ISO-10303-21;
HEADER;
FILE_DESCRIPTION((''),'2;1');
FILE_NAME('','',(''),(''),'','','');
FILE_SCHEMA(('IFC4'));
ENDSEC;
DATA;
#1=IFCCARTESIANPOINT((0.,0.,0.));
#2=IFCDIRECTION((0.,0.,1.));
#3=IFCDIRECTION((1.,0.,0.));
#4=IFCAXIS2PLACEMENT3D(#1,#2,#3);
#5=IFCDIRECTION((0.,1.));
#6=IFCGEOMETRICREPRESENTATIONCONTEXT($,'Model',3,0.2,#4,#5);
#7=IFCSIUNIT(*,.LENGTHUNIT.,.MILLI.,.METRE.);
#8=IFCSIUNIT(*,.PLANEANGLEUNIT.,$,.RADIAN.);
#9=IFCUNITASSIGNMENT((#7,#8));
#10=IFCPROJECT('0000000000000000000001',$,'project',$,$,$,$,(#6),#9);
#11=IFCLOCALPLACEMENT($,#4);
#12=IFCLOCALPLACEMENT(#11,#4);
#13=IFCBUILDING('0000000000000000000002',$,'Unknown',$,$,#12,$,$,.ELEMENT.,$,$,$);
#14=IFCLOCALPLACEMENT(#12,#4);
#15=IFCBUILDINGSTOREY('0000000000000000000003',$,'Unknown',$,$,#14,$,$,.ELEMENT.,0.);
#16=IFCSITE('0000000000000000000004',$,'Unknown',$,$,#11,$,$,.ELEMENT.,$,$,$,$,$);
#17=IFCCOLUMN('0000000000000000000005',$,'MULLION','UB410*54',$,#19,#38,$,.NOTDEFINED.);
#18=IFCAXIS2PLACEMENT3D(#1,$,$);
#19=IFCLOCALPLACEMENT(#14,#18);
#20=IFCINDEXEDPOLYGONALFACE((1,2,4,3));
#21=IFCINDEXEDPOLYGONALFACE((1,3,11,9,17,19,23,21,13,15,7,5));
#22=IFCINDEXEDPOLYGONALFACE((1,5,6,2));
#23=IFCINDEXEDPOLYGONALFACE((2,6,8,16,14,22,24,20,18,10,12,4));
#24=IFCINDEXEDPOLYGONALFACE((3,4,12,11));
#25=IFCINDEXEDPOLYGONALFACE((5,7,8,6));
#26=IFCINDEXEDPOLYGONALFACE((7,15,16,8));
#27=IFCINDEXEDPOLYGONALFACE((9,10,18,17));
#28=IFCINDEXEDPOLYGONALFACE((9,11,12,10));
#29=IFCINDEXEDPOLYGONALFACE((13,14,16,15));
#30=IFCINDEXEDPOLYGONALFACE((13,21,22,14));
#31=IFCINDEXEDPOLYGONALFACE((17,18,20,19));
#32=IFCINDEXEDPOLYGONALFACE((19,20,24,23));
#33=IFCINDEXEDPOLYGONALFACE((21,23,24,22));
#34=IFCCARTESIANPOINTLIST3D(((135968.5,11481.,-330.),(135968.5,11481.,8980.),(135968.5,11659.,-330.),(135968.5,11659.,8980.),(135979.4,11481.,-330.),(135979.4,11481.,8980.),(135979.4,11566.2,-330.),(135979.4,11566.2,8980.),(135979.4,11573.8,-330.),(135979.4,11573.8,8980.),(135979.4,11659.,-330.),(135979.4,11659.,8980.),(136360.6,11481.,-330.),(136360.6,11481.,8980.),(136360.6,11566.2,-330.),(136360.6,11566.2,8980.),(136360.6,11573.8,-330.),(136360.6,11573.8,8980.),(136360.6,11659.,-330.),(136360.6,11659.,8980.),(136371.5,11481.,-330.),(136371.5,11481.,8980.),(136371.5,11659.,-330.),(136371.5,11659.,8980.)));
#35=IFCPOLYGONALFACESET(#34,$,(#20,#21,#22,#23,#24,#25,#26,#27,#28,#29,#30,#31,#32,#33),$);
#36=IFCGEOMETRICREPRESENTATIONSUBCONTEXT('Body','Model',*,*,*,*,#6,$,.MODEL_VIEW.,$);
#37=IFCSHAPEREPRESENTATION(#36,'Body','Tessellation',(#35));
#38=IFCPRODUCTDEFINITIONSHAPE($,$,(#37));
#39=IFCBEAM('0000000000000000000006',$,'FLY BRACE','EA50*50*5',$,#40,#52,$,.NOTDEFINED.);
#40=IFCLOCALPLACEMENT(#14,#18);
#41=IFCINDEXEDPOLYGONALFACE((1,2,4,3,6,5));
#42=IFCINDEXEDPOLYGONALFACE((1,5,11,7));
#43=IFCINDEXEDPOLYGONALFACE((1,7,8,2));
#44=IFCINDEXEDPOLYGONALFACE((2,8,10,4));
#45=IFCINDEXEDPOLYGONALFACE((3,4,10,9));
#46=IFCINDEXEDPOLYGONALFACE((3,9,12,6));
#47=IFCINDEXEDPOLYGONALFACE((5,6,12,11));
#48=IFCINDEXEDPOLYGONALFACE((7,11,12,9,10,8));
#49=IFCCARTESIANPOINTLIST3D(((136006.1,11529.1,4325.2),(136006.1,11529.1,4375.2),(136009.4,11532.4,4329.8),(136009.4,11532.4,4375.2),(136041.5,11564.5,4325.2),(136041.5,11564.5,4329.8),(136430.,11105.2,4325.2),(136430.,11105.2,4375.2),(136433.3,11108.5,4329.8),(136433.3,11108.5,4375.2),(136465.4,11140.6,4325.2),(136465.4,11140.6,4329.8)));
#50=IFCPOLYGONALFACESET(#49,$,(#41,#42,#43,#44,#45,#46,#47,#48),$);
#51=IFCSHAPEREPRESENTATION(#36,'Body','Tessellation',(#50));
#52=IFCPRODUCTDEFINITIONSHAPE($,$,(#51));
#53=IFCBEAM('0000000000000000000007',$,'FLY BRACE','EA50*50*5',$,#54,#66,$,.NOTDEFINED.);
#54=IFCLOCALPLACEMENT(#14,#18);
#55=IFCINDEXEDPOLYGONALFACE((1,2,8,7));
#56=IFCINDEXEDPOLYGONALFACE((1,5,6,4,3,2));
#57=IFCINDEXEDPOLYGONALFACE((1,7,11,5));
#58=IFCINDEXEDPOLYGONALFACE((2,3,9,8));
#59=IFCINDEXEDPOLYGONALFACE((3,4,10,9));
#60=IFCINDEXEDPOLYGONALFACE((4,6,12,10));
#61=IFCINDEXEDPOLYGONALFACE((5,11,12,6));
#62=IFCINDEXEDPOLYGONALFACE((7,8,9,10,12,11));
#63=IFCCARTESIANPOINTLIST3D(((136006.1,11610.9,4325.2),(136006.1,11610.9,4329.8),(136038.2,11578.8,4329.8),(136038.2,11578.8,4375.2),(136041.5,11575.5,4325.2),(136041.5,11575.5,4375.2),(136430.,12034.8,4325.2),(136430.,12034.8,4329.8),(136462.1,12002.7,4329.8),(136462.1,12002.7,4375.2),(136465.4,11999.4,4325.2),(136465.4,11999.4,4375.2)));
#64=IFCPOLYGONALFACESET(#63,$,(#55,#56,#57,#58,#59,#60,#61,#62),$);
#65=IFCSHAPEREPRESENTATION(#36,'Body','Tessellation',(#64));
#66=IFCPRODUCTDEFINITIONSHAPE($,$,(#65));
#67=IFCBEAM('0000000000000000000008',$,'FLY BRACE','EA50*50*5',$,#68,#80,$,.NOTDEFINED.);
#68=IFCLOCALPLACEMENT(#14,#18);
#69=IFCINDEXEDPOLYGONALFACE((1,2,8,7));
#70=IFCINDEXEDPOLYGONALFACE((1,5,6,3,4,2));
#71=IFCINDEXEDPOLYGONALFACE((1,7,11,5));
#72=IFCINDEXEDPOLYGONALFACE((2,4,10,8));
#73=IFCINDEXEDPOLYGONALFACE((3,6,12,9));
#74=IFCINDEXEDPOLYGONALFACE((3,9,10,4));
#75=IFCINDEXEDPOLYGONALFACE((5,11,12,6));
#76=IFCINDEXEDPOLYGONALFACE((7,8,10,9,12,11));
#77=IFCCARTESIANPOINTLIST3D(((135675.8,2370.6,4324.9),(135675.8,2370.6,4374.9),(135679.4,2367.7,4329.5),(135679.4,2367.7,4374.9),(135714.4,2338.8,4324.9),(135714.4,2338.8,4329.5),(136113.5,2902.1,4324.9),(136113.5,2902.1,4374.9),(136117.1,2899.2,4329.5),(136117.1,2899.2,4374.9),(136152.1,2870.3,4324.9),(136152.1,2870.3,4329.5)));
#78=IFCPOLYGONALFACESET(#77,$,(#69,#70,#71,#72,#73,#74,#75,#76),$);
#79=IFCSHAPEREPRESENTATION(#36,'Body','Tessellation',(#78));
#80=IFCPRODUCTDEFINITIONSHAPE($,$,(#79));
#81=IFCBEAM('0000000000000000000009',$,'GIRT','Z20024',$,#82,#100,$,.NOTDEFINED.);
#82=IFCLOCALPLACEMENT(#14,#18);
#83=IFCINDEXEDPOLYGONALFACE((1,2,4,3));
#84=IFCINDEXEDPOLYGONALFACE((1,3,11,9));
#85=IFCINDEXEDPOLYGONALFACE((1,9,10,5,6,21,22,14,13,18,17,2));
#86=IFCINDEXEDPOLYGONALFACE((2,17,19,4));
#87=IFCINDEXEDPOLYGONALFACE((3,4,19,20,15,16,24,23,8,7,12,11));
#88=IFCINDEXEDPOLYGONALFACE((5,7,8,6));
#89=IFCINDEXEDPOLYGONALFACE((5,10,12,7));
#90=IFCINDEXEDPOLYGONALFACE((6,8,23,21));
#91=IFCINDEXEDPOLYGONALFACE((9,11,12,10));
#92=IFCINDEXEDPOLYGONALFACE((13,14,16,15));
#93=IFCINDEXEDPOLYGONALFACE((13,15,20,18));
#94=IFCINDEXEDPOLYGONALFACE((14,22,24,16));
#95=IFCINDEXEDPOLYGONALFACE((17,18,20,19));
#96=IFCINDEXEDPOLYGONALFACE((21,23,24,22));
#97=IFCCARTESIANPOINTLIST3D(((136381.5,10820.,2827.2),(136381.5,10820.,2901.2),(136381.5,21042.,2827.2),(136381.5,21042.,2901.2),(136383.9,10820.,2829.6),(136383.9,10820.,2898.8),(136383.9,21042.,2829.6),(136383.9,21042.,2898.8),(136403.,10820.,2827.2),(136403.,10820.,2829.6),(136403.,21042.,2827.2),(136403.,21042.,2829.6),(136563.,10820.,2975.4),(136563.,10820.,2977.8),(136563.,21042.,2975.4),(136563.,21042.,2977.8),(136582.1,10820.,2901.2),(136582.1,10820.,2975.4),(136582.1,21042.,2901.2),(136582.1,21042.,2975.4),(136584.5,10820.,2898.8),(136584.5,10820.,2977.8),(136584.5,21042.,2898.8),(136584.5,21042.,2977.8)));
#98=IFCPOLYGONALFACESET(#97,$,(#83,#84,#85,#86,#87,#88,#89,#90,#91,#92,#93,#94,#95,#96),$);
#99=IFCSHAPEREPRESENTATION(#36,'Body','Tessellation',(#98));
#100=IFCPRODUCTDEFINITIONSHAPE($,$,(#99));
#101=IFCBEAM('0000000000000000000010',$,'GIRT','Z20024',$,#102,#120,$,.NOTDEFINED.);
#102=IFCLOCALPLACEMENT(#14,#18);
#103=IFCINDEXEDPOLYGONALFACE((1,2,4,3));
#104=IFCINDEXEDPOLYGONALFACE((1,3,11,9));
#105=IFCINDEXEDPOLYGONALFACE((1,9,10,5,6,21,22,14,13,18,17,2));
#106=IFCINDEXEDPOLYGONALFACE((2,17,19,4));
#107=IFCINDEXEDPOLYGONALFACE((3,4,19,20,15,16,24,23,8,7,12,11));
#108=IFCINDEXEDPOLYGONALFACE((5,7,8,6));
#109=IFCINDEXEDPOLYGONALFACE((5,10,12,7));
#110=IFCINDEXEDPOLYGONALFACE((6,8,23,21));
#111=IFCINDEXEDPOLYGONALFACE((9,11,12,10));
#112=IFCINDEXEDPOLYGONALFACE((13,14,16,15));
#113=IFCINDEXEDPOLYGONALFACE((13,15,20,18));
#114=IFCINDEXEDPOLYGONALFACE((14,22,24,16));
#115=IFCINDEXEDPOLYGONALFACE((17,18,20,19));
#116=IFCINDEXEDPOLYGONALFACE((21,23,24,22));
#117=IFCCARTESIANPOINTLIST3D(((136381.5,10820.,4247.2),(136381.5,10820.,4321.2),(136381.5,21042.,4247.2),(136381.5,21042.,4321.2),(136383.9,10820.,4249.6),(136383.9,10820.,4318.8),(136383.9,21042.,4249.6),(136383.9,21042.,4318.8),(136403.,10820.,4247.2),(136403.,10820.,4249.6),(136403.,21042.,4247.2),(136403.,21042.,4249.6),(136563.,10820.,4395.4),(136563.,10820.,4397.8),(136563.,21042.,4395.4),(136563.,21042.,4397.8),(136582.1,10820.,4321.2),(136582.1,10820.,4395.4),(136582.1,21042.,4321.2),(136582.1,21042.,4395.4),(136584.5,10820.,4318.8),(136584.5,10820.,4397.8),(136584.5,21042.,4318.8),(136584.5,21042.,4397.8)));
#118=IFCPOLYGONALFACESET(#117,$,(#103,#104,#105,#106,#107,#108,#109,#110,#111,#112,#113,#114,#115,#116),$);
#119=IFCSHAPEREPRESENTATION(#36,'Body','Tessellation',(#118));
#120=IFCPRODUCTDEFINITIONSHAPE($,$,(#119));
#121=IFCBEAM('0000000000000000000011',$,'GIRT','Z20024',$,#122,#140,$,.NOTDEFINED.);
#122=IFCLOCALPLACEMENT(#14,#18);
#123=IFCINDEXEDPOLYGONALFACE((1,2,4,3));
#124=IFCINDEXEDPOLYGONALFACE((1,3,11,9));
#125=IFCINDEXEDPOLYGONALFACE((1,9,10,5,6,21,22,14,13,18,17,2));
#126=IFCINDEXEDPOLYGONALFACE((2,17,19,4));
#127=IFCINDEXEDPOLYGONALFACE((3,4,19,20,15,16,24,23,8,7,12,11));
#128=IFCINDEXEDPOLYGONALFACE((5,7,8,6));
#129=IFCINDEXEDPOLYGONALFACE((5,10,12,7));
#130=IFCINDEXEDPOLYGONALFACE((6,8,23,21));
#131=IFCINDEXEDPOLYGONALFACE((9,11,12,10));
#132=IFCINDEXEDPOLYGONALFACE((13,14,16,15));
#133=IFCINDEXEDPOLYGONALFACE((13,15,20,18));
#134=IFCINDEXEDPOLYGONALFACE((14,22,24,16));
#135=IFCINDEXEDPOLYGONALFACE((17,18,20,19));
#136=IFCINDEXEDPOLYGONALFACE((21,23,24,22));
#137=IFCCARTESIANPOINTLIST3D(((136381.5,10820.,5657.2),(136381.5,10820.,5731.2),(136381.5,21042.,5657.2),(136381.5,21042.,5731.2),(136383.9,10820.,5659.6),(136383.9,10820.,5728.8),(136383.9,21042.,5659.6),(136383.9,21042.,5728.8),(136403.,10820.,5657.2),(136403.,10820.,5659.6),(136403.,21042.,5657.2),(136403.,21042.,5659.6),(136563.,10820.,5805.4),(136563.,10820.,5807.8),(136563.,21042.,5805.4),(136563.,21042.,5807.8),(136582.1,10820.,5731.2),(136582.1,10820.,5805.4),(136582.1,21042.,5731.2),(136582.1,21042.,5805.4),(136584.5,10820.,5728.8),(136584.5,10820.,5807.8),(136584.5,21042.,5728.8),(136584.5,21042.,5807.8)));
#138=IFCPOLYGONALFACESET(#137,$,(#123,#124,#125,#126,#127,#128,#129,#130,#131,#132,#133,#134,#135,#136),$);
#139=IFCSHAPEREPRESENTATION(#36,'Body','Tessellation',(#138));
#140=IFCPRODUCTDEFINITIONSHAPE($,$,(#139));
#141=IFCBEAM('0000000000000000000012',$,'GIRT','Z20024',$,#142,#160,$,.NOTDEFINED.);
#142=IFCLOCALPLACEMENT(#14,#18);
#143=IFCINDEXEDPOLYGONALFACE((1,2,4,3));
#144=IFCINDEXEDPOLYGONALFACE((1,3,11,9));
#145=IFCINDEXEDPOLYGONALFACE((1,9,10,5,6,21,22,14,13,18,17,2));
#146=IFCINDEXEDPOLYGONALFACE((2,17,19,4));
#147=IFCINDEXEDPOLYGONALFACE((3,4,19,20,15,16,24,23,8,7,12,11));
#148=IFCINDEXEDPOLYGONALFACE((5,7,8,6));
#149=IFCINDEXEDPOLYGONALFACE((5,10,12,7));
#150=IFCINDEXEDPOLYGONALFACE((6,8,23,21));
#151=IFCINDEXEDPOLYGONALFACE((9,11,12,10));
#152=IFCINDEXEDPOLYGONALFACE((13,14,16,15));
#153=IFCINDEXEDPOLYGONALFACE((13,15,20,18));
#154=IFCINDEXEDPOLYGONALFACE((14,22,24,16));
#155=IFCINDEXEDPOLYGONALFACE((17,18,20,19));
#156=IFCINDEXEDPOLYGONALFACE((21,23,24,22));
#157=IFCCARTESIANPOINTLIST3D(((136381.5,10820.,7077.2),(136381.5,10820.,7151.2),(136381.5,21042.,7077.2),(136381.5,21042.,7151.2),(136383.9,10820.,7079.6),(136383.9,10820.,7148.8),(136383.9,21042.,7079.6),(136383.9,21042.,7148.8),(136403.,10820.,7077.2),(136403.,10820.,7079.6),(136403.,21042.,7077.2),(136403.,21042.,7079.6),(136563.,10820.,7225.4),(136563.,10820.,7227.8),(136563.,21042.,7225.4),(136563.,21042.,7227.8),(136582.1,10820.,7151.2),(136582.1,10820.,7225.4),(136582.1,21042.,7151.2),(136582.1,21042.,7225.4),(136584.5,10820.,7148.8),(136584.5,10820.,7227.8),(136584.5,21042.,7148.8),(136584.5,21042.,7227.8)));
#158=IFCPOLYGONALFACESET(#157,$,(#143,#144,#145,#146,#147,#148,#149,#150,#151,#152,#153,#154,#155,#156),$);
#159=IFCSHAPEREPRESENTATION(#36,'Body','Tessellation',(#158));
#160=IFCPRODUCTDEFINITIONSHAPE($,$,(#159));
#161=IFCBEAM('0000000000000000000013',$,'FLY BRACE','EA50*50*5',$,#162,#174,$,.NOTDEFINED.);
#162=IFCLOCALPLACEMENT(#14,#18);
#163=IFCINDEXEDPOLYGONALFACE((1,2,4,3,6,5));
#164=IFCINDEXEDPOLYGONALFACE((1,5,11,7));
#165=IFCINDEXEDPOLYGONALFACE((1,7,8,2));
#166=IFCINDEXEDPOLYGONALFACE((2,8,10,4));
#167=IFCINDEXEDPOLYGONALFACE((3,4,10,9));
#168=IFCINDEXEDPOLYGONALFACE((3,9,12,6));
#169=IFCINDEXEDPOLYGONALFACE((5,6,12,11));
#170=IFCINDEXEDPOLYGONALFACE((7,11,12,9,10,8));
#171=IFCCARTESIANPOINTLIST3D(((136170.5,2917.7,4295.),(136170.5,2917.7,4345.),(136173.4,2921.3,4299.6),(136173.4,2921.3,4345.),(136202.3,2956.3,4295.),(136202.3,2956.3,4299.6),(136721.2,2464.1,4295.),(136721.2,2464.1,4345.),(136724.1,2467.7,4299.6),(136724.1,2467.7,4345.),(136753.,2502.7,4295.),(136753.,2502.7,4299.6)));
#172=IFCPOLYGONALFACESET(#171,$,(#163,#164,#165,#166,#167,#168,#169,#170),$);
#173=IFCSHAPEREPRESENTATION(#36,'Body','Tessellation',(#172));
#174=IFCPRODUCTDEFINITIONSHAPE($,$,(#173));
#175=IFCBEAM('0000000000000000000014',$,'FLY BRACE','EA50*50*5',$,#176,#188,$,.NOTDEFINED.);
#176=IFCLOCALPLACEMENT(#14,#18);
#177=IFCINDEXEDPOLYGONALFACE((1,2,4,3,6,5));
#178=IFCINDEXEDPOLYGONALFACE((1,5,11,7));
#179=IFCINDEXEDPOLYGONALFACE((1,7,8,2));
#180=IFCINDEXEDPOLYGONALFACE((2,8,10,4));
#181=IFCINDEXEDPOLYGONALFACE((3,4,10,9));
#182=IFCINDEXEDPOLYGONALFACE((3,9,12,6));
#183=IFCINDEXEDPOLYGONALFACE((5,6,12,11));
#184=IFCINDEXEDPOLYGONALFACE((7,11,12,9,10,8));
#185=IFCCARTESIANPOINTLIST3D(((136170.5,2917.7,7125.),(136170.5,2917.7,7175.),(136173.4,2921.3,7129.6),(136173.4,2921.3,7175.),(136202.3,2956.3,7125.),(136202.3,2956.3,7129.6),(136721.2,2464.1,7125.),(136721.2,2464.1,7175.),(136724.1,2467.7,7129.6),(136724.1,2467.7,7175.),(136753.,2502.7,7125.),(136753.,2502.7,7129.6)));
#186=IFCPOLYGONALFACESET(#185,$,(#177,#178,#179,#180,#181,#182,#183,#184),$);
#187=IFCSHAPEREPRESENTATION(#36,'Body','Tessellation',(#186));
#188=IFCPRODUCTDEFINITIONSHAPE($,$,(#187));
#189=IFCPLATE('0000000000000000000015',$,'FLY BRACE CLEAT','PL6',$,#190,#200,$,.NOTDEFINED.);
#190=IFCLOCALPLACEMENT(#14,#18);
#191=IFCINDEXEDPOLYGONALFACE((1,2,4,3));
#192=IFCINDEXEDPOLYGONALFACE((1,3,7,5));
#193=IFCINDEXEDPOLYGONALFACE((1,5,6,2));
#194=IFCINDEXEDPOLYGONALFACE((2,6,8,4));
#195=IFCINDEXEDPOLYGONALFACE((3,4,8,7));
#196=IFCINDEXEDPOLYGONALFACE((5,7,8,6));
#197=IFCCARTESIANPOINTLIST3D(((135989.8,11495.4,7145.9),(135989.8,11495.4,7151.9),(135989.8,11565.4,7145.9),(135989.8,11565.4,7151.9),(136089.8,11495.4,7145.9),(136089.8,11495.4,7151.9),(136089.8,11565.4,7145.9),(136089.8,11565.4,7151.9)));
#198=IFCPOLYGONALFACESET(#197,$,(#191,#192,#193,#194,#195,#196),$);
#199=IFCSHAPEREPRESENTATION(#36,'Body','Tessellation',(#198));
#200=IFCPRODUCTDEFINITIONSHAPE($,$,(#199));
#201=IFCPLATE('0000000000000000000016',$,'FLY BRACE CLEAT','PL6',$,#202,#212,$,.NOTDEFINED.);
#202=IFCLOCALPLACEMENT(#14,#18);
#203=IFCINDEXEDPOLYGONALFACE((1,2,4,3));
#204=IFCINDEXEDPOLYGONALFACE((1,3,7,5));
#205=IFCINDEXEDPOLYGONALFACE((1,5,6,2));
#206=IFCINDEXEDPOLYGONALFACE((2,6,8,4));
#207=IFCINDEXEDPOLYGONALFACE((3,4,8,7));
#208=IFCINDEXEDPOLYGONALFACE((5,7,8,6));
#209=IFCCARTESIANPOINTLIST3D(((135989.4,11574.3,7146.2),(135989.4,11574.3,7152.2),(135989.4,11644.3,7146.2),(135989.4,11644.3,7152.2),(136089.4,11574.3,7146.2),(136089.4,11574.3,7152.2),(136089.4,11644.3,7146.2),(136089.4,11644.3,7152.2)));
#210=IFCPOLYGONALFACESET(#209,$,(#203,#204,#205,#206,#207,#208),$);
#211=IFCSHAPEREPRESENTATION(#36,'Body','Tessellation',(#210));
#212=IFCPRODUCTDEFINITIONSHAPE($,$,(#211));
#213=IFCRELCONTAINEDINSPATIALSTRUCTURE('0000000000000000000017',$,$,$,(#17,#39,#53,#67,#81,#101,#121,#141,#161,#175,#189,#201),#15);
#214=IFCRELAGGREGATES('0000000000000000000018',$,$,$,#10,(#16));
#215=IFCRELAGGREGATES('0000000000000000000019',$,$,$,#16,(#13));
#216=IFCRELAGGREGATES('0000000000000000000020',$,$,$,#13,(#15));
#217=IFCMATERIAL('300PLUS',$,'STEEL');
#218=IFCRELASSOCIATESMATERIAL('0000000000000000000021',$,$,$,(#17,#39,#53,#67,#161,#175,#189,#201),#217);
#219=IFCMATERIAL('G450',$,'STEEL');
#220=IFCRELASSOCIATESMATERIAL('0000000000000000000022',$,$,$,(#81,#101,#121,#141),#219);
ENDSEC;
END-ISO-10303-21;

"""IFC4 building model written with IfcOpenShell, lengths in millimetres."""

from ifc_helpers import new_model, si_unit, direction, frame, origin_with_axes, place, context, subcontext, project, spatial, line, indexed_curve, outline, extrude, material, element, save


model = new_model("IFC4")

# Units and contexts
model_context = context("Model", 3, precision=0.2, world=origin_with_axes(), true_north=direction((0.0, 1.0)))
body_context = subcontext(model_context, "Body", "Model", "MODEL_VIEW")
ifc_project = project(units=[si_unit("LENGTHUNIT", "METRE", prefix="MILLI"), si_unit("PLANEANGLEUNIT", "RADIAN")], contexts=[model_context])

# Site, building, storey
site_placement = place(None, origin_with_axes())
site = spatial("IfcSite", under=ifc_project, at=site_placement, Name="Unknown", CompositionType="ELEMENT")
building_placement = place(site_placement, origin_with_axes())
building = spatial("IfcBuilding", under=site, at=building_placement, Name="Unknown", CompositionType="ELEMENT")
storey_placement = place(building_placement, origin_with_axes())
storey = spatial("IfcBuildingStorey", under=building, at=storey_placement, Name="Unknown", CompositionType="ELEMENT", Elevation=0.0)

# Column
ifc_material_1 = material(Name="G450", Category="STEEL")
ifc_material_2 = material(Name="300PLUS", Category="STEEL")
column_placement = place(storey_placement, frame((136170.0, 11570.0, -330.0), z_axis=(0.0, -1.0, 0.0), x_axis=(0.0, 0.0, 1.0)))
element("IfcColumn", 1, at=column_placement, inside=storey, material=ifc_material_2, Name="MULLION", Description="UB410*54", PredefinedType="NOTDEFINED", context=body_context, shape_type="SolidModel", body=[
    extrude(outline(indexed_curve([(-89.0, -201.5), (89.0, -201.5), (89.0, -190.6), (3.8, -190.6), (3.8, 190.6), (89.0, 190.6), (89.0, 201.5), (-89.0, 201.5), (-89.0, 190.6), (-3.8, 190.6), (-3.8, -190.6), (-89.0, -190.6)], segments=[line(1, 2, 3, 4, 5, 6, 7, 8, 9, 10, 11, 12, 1)])), frame((0.0, 0.0, 0.0), z_axis=(-1.0, 0.0, 0.0), x_axis=(0.0, 0.0, 1.0)), (0.0, 0.0, -1.0), 9310.0),
])

# Beams
for number, where, z_axis, x_axis, name in (
    (2, (136023.8, 11546.8, 4350.2), (0.0, 0.0, 1.0), (0.707107, -0.707107, 0.0), "FLY BRACE"),
    (3, (136023.8, 11593.2, 4350.2), (0.0, 0.0, 1.0), (0.707107, 0.707107, 0.0), "FLY BRACE"),
):
    element("IfcBeam", number, at=place(storey_placement, frame(where, z_axis=z_axis, x_axis=x_axis)), inside=storey, material=ifc_material_2, Name=name, Description="EA50*50*5", PredefinedType="NOTDEFINED", context=body_context, shape_type="SolidModel", body=[
        extrude(outline(indexed_curve([(-25.0, -25.0), (25.0, -25.0), (25.0, -20.4), (-20.4, -20.4), (-20.4, 25.0), (-25.0, 25.0)], segments=[line(1, 2, 3, 4, 5, 6, 1)])), frame((0.0, 0.0, 0.0), z_axis=(-1.0, 0.0, 0.0), x_axis=(0.0, 0.0, 1.0)), (0.0, 0.0, -1.0), 599.5),
    ])
beam_placement = place(storey_placement, frame((136132.8, 2886.2, 4349.9), z_axis=(0.0, 0.0, 1.0), x_axis=(-0.635702, -0.771934, 0.0)))
element("IfcBeam", 4, at=beam_placement, inside=storey, material=ifc_material_2, Name="FLY BRACE", Description="EA50*50*5", PredefinedType="NOTDEFINED", context=body_context, shape_type="SolidModel", body=[
    extrude(outline(indexed_curve([(-25.0, -25.0), (25.0, -25.0), (25.0, -20.4), (-20.4, -20.4), (-20.4, 25.0), (-25.0, 25.0)], segments=[line(1, 2, 3, 4, 5, 6, 1)])), frame((0.0, 0.0, 0.0), z_axis=(-1.0, 0.0, 0.0), x_axis=(0.0, 0.0, 1.0)), (0.0, 0.0, -1.0), 688.5),
])
for number, where, z_axis, x_axis, name in (
    (5, (136483.0, 10820.0, 2900.0), (0.0, 0.0, -1.0), (0.0, 1.0, 0.0), "GIRT"),
    (6, (136483.0, 10820.0, 4320.0), (0.0, 0.0, -1.0), (0.0, 1.0, 0.0), "GIRT"),
    (7, (136483.0, 10820.0, 5730.0), (0.0, 0.0, -1.0), (0.0, 1.0, 0.0), "GIRT"),
    (8, (136483.0, 10820.0, 7150.0), (0.0, 0.0, -1.0), (0.0, 1.0, 0.0), "GIRT"),
):
    element("IfcBeam", number, at=place(storey_placement, frame(where, z_axis=z_axis, x_axis=x_axis)), inside=storey, material=ifc_material_1, Name=name, Description="Z20024", PredefinedType="NOTDEFINED", context=body_context, shape_type="SolidModel", body=[
        extrude(outline(indexed_curve([(72.8, -101.5), (72.8, -80.0), (70.4, -80.0), (70.4, -99.1), (1.2, -99.1), (1.2, 101.5), (-77.8, 101.5), (-77.8, 80.0), (-75.4, 80.0), (-75.4, 99.1), (-1.2, 99.1), (-1.2, -101.5)], segments=[line(1, 2, 3, 4, 5, 6, 7, 8, 9, 10, 11, 12, 1)])), frame((0.0, 0.0, 0.0), z_axis=(-1.0, 0.0, 0.0), x_axis=(0.0, 0.0, 1.0)), (0.0, 0.0, -1.0), 10222.0),
    ])
for number, where, z_axis, x_axis, name in (
    (9, (136186.4, 2937.0, 4320.0), (0.0, 0.0, 1.0), (0.771874, -0.635776, 0.0), "FLY BRACE"),
    (10, (136186.4, 2937.0, 7150.0), (0.0, 0.0, 1.0), (0.771874, -0.635776, 0.0), "FLY BRACE"),
):
    element("IfcBeam", number, at=place(storey_placement, frame(where, z_axis=z_axis, x_axis=x_axis)), inside=storey, material=ifc_material_2, Name=name, Description="EA50*50*5", PredefinedType="NOTDEFINED", context=body_context, shape_type="SolidModel", body=[
        extrude(outline(indexed_curve([(-25.0, -25.0), (25.0, -25.0), (25.0, -20.4), (-20.4, -20.4), (-20.4, 25.0), (-25.0, 25.0)], segments=[line(1, 2, 3, 4, 5, 6, 1)])), frame((0.0, 0.0, 0.0), z_axis=(-1.0, 0.0, 0.0), x_axis=(0.0, 0.0, 1.0)), (0.0, 0.0, -1.0), 713.5),
    ])

# Plates
for number, where, z_axis, x_axis, name in (
    (11, (135989.8, 11565.4, 7148.9), (0.0, 0.0, 1.0), (0.0, -1.0, 0.0), "FLY BRACE CLEAT"),
    (12, (136089.4, 11574.3, 7149.2), (0.0, 0.0, 1.0), (0.0, 1.0, 0.0), "FLY BRACE CLEAT"),
):
    element("IfcPlate", number, at=place(storey_placement, frame(where, z_axis=z_axis, x_axis=x_axis)), inside=storey, material=ifc_material_2, Name=name, Description="PL6", PredefinedType="NOTDEFINED", context=body_context, shape_type="SolidModel", body=[
        extrude(outline(indexed_curve([(0.0, 0.0), (70.0, 0.0), (70.0, 100.0), (0.0, 100.0)], segments=[line(1, 2, 3, 4, 1)])), frame((0.0, 0.0, 3.0), z_axis=(0.0, 0.0, 1.0), x_axis=(1.0, 0.0, 0.0)), (0.0, 0.0, -1.0), 6.0),
    ])

save(model, "model.ifc")
